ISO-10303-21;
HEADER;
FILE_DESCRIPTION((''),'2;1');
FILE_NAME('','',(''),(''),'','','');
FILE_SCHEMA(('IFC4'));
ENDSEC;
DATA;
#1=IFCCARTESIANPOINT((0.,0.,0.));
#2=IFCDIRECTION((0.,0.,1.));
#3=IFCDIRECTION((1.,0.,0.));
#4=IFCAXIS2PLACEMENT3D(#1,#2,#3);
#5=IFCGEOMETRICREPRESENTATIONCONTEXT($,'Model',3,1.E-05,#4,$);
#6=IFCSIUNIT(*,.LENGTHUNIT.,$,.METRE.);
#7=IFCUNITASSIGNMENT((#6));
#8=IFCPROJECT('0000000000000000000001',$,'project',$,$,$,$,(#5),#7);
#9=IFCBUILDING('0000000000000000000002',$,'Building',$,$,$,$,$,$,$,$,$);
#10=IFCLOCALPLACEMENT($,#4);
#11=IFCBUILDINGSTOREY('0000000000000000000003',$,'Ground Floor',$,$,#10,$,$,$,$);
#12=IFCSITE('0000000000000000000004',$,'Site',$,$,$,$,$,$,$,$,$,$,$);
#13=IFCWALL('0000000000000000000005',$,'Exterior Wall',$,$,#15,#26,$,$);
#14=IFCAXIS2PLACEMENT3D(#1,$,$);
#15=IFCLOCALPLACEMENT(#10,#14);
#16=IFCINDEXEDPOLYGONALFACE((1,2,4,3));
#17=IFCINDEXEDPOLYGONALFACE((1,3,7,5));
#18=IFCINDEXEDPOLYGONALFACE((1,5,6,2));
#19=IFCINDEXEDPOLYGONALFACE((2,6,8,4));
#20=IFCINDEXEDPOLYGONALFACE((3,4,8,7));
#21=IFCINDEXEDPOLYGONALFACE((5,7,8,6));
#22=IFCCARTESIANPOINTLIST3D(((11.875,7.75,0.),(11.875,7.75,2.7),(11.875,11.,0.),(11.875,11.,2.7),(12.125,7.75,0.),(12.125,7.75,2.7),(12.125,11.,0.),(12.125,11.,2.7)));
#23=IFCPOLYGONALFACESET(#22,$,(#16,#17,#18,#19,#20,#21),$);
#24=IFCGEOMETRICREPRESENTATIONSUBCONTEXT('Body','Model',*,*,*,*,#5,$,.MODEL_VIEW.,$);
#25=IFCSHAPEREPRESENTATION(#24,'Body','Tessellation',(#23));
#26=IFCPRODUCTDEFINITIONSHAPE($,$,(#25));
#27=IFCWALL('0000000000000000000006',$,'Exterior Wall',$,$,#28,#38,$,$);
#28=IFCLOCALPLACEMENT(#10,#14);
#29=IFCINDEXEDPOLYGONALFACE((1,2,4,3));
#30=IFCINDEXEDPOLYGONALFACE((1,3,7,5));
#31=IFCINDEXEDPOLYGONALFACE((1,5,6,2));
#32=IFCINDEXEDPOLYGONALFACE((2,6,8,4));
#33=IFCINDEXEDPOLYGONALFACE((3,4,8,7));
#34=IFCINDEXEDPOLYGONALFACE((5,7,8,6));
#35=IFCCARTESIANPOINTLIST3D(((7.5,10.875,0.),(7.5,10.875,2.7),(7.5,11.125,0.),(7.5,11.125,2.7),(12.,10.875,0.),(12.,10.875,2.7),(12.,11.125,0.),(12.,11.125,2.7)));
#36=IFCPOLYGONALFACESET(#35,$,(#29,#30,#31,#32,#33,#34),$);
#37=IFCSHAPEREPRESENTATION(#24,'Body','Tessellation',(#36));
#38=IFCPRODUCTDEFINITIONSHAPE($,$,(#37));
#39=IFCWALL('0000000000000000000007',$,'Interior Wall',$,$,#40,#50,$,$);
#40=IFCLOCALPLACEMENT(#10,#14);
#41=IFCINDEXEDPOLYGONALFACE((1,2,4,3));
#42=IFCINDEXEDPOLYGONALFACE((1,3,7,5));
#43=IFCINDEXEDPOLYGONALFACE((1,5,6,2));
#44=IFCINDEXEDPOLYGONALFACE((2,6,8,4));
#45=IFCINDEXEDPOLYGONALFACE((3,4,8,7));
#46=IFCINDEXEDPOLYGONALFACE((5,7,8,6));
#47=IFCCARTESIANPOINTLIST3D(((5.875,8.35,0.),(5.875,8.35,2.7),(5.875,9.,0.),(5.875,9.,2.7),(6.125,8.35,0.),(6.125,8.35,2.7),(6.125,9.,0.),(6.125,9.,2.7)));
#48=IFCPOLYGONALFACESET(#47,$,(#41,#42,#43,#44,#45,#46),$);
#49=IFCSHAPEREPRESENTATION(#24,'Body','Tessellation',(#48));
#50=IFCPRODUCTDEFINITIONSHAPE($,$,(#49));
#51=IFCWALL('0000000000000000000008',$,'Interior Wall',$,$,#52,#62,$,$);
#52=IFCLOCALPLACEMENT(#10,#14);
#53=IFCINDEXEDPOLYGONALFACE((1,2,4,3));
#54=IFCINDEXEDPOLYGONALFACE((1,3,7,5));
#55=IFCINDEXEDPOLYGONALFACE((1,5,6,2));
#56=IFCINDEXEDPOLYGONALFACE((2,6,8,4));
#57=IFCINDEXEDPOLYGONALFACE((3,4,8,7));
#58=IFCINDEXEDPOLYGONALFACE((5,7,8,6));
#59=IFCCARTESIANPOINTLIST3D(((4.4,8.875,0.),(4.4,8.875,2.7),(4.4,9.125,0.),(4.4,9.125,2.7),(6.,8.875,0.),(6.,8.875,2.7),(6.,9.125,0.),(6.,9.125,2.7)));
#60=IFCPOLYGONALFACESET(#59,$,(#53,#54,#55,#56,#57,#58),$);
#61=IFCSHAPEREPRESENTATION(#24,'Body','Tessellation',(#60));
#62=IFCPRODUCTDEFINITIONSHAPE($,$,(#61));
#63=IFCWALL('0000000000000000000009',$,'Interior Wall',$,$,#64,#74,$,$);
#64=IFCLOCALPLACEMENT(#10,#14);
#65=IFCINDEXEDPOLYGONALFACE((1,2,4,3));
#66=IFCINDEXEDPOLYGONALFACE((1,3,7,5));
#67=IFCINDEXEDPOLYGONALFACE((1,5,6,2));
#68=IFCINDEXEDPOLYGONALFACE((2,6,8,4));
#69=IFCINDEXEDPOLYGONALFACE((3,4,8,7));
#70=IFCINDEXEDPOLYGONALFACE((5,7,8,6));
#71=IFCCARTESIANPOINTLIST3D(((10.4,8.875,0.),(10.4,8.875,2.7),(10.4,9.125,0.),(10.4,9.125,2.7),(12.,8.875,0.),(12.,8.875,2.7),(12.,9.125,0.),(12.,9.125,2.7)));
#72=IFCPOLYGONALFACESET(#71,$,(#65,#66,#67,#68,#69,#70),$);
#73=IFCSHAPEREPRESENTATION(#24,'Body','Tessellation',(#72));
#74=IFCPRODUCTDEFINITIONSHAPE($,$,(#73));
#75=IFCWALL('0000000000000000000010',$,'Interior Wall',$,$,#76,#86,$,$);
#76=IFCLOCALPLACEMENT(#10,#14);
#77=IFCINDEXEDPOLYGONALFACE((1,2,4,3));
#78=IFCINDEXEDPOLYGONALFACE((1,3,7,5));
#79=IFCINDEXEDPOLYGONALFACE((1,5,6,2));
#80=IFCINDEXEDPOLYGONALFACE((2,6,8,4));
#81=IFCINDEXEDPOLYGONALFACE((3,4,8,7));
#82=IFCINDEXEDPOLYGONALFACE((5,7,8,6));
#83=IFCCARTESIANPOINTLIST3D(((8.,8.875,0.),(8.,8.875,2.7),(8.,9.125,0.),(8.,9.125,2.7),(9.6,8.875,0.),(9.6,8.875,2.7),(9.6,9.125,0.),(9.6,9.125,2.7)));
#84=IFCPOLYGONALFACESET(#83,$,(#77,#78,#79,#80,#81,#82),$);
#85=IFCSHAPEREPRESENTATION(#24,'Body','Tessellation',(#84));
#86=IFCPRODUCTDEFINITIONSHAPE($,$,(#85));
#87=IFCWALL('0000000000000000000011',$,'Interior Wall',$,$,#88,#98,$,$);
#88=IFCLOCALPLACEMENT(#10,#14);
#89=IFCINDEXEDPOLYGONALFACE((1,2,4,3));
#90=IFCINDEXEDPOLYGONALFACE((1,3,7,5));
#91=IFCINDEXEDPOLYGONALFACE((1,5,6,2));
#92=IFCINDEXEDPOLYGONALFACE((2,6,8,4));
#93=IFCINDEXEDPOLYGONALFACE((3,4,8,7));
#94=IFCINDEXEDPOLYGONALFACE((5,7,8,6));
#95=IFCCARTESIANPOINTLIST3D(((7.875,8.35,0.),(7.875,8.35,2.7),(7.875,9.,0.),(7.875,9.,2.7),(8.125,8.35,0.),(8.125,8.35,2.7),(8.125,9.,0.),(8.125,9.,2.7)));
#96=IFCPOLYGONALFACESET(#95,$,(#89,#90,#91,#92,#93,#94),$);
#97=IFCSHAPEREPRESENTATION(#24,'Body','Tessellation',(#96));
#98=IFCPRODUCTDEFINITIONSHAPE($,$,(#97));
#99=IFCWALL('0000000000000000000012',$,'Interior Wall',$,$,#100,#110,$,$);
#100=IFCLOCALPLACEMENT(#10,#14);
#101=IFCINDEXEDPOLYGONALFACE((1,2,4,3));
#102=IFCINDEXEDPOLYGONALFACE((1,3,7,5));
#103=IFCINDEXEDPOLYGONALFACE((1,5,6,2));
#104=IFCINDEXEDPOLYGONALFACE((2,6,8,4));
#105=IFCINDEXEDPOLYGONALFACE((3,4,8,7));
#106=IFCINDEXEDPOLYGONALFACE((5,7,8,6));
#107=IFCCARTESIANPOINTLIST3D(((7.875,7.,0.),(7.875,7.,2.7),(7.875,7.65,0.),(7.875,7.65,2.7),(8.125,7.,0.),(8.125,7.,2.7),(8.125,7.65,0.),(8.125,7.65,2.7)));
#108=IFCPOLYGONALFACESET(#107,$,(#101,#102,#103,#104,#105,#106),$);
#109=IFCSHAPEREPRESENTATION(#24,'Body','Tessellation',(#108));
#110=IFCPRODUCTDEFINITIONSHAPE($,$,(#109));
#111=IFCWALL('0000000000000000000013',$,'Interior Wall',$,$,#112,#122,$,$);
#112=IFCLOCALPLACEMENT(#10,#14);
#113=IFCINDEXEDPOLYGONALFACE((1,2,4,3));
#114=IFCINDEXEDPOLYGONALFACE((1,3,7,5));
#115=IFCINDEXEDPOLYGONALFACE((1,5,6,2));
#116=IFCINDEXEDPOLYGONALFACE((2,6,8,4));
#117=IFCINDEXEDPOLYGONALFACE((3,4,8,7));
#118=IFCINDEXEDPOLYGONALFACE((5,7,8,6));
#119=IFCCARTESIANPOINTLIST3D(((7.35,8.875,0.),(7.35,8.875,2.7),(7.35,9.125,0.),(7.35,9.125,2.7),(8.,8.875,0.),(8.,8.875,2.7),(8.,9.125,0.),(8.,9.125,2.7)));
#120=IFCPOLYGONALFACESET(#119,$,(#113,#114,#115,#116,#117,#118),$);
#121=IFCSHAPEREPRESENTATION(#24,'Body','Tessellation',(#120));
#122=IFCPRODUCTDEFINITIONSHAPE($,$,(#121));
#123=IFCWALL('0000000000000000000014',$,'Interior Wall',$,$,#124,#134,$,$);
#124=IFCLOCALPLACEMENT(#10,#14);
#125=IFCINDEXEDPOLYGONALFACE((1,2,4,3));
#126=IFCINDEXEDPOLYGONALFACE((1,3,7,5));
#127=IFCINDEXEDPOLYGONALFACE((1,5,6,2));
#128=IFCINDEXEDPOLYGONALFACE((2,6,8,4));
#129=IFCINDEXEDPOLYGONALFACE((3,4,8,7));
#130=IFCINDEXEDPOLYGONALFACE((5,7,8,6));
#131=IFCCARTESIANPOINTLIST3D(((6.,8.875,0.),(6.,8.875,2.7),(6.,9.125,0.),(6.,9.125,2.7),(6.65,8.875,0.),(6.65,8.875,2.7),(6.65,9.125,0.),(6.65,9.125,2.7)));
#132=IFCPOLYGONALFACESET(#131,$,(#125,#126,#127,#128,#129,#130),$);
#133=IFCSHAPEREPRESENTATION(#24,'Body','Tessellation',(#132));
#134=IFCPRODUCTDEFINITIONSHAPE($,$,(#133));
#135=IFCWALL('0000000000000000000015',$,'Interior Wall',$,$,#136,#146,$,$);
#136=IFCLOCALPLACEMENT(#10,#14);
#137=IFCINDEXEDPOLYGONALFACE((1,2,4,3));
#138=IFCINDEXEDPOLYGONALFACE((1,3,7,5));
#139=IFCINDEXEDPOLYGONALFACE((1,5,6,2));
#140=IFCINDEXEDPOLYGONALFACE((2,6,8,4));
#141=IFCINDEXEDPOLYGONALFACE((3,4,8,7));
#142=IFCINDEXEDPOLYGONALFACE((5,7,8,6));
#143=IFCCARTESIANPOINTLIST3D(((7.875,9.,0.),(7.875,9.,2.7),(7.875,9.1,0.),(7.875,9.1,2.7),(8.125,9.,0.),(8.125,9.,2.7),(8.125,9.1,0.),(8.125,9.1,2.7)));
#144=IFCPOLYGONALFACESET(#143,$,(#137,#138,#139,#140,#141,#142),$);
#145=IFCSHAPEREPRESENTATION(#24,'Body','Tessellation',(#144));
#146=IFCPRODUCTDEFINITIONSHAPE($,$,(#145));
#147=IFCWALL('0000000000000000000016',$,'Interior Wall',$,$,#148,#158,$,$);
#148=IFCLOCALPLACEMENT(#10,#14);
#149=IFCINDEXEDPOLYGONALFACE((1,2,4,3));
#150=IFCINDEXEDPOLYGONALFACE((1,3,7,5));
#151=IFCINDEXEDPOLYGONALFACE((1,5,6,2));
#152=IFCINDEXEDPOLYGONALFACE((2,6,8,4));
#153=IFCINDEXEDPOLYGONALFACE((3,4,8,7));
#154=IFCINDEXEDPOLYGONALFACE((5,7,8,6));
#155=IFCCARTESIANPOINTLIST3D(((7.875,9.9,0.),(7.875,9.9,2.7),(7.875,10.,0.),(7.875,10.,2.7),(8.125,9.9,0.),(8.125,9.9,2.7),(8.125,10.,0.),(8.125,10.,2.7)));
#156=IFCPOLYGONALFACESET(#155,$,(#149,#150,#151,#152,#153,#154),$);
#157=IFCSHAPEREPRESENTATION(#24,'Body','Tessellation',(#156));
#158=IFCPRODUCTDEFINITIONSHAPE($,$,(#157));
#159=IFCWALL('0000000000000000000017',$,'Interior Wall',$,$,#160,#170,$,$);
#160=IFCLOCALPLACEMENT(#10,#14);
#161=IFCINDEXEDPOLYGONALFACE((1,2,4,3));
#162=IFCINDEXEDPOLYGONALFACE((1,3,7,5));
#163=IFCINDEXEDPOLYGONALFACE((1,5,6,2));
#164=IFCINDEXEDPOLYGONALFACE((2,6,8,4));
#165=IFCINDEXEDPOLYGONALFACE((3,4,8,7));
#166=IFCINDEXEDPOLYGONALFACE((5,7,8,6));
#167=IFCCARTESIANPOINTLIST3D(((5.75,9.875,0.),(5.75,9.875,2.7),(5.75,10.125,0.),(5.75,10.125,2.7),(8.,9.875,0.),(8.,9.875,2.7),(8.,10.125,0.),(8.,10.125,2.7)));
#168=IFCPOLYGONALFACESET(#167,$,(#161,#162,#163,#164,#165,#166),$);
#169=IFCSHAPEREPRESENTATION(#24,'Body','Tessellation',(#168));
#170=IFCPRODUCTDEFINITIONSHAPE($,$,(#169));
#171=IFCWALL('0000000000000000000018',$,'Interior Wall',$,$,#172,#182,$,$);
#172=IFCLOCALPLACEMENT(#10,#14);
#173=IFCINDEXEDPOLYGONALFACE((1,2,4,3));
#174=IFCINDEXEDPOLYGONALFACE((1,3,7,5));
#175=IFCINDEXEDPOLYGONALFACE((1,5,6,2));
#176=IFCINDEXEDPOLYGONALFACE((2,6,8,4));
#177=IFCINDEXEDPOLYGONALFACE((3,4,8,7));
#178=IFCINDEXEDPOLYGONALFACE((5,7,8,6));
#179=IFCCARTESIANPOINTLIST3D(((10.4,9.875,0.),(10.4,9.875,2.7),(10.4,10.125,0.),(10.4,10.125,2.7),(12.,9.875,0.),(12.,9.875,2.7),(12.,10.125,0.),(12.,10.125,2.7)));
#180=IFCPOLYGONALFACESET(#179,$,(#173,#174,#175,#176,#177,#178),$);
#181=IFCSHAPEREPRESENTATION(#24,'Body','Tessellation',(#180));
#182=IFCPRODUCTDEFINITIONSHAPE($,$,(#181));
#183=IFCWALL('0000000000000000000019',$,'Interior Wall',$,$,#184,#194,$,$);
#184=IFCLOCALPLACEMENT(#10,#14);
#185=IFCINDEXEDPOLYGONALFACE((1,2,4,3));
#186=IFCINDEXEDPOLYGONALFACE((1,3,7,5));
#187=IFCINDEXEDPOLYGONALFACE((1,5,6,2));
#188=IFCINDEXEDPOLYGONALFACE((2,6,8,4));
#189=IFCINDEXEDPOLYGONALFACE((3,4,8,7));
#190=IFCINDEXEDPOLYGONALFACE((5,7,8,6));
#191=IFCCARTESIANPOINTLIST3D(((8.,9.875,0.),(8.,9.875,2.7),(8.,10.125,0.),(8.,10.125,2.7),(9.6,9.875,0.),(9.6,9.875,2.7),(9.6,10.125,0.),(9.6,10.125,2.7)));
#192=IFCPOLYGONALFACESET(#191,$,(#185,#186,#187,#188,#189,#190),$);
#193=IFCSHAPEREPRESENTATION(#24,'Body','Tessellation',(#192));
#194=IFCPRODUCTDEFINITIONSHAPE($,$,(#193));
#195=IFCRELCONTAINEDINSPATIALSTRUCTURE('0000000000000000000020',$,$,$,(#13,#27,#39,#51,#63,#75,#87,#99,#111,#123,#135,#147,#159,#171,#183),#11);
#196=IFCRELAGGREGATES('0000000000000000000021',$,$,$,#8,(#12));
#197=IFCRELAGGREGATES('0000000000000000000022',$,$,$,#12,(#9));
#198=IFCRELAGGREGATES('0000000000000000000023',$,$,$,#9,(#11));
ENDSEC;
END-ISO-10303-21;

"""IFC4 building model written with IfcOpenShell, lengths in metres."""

from ifc_helpers import new_model, si_unit, frame, origin_with_axes, place, context, subcontext, project, spatial, indexed_curve, outline, extrude, element, save


model = new_model("IFC4")

# Units and contexts
model_context = context("Model", 3, precision=1e-05, world=origin_with_axes())
body_context = subcontext(model_context, "Body", "Model", "MODEL_VIEW")
ifc_project = project(units=[si_unit("LENGTHUNIT", "METRE")], contexts=[model_context])

# Site, building, storey
site = spatial("IfcSite", under=ifc_project, Name="Site")
building = spatial("IfcBuilding", under=site, Name="Building")
storey_placement = place(None, origin_with_axes())
storey = spatial("IfcBuildingStorey", under=building, at=storey_placement, Name="Ground Floor")

# Walls
wall_1_placement = place(storey_placement, frame((12.0, 7.75, 0.0), z_axis=(0.0, 0.0, 1.0), x_axis=(0.0, 1.0, 0.0)))
element("IfcWall", 1, at=wall_1_placement, inside=storey, Name="Exterior Wall", context=body_context, shape_type="SweptSolid", body=[
    extrude(outline(indexed_curve([(0.0, 0.0), (0.0, 0.25), (3.25, 0.25), (3.25, 0.0), (0.0, 0.0)], self_intersect=False)), frame((0.0, -0.125, 0.0), z_axis=(0.0, 0.0, 1.0), x_axis=(1.0, 0.0, 0.0)), (0.0, 0.0, 1.0), 2.7),
])
wall_2_placement = place(storey_placement, frame((12.0, 11.0, 0.0), z_axis=(0.0, 0.0, 1.0), x_axis=(-1.0, 0.0, 0.0)))
element("IfcWall", 2, at=wall_2_placement, inside=storey, Name="Exterior Wall", context=body_context, shape_type="SweptSolid", body=[
    extrude(outline(indexed_curve([(0.0, 0.0), (0.0, 0.25), (4.5, 0.25), (4.5, 0.0), (0.0, 0.0)], self_intersect=False)), frame((0.0, -0.125, 0.0), z_axis=(0.0, 0.0, 1.0), x_axis=(1.0, 0.0, 0.0)), (0.0, 0.0, 1.0), 2.7),
])
wall_3_placement = place(storey_placement, frame((6.0, 8.35, 0.0), z_axis=(0.0, 0.0, 1.0), x_axis=(0.0, 1.0, 0.0)))
element("IfcWall", 3, at=wall_3_placement, inside=storey, Name="Interior Wall", context=body_context, shape_type="SweptSolid", body=[
    extrude(outline(indexed_curve([(0.0, 0.0), (0.0, 0.25), (0.65, 0.25), (0.65, 0.0), (0.0, 0.0)], self_intersect=False)), frame((0.0, -0.125, 0.0), z_axis=(0.0, 0.0, 1.0), x_axis=(1.0, 0.0, 0.0)), (0.0, 0.0, 1.0), 2.7),
])
for number, where, z_axis, x_axis, name in (
    (4, (6.0, 9.0, 0.0), (0.0, 0.0, 1.0), (-1.0, 0.0, 0.0), "Interior Wall"),
    (5, (12.0, 9.0, 0.0), (0.0, 0.0, 1.0), (-1.0, 0.0, 0.0), "Interior Wall"),
    (6, (9.6, 9.0, 0.0), (0.0, 0.0, 1.0), (-1.0, 0.0, 0.0), "Interior Wall"),
):
    element("IfcWall", number, at=place(storey_placement, frame(where, z_axis=z_axis, x_axis=x_axis)), inside=storey, Name=name, context=body_context, shape_type="SweptSolid", body=[
        extrude(outline(indexed_curve([(0.0, 0.0), (0.0, 0.25), (1.6, 0.25), (1.6, 0.0), (0.0, 0.0)], self_intersect=False)), frame((0.0, -0.125, 0.0), z_axis=(0.0, 0.0, 1.0), x_axis=(1.0, 0.0, 0.0)), (0.0, 0.0, 1.0), 2.7),
    ])
for number, where, z_axis, x_axis, name in (
    (7, (8.0, 9.0, 0.0), (0.0, 0.0, 1.0), (0.0, -1.0, 0.0), "Interior Wall"),
    (8, (8.0, 7.65, 0.0), (0.0, 0.0, 1.0), (0.0, -1.0, 0.0), "Interior Wall"),
    (9, (8.0, 9.0, 0.0), (0.0, 0.0, 1.0), (-1.0, 0.0, 0.0), "Interior Wall"),
    (10, (6.65, 9.0, 0.0), (0.0, 0.0, 1.0), (-1.0, 0.0, 0.0), "Interior Wall"),
):
    element("IfcWall", number, at=place(storey_placement, frame(where, z_axis=z_axis, x_axis=x_axis)), inside=storey, Name=name, context=body_context, shape_type="SweptSolid", body=[
        extrude(outline(indexed_curve([(0.0, 0.0), (0.0, 0.25), (0.65, 0.25), (0.65, 0.0), (0.0, 0.0)], self_intersect=False)), frame((0.0, -0.125, 0.0), z_axis=(0.0, 0.0, 1.0), x_axis=(1.0, 0.0, 0.0)), (0.0, 0.0, 1.0), 2.7),
    ])
for number, where, z_axis, x_axis, name in (
    (11, (8.0, 9.0, 0.0), (0.0, 0.0, 1.0), (0.0, 1.0, 0.0), "Interior Wall"),
    (12, (8.0, 9.9, 0.0), (0.0, 0.0, 1.0), (0.0, 1.0, 0.0), "Interior Wall"),
):
    element("IfcWall", number, at=place(storey_placement, frame(where, z_axis=z_axis, x_axis=x_axis)), inside=storey, Name=name, context=body_context, shape_type="SweptSolid", body=[
        extrude(outline(indexed_curve([(0.0, 0.0), (0.0, 0.25), (0.1, 0.25), (0.1, 0.0), (0.0, 0.0)], self_intersect=False)), frame((0.0, -0.125, 0.0), z_axis=(0.0, 0.0, 1.0), x_axis=(1.0, 0.0, 0.0)), (0.0, 0.0, 1.0), 2.7),
    ])
wall_4_placement = place(storey_placement, frame((8.0, 10.0, 0.0), z_axis=(0.0, 0.0, 1.0), x_axis=(-1.0, 0.0, 0.0)))
element("IfcWall", 13, at=wall_4_placement, inside=storey, Name="Interior Wall", context=body_context, shape_type="SweptSolid", body=[
    extrude(outline(indexed_curve([(0.0, 0.0), (0.0, 0.25), (2.25, 0.25), (2.25, 0.0), (0.0, 0.0)], self_intersect=False)), frame((0.0, -0.125, 0.0), z_axis=(0.0, 0.0, 1.0), x_axis=(1.0, 0.0, 0.0)), (0.0, 0.0, 1.0), 2.7),
])
for number, where, z_axis, x_axis, name in (
    (14, (12.0, 10.0, 0.0), (0.0, 0.0, 1.0), (-1.0, 0.0, 0.0), "Interior Wall"),
    (15, (9.6, 10.0, 0.0), (0.0, 0.0, 1.0), (-1.0, 0.0, 0.0), "Interior Wall"),
):
    element("IfcWall", number, at=place(storey_placement, frame(where, z_axis=z_axis, x_axis=x_axis)), inside=storey, Name=name, context=body_context, shape_type="SweptSolid", body=[
        extrude(outline(indexed_curve([(0.0, 0.0), (0.0, 0.25), (1.6, 0.25), (1.6, 0.0), (0.0, 0.0)], self_intersect=False)), frame((0.0, -0.125, 0.0), z_axis=(0.0, 0.0, 1.0), x_axis=(1.0, 0.0, 0.0)), (0.0, 0.0, 1.0), 2.7),
    ])

save(model, "model.ifc")
